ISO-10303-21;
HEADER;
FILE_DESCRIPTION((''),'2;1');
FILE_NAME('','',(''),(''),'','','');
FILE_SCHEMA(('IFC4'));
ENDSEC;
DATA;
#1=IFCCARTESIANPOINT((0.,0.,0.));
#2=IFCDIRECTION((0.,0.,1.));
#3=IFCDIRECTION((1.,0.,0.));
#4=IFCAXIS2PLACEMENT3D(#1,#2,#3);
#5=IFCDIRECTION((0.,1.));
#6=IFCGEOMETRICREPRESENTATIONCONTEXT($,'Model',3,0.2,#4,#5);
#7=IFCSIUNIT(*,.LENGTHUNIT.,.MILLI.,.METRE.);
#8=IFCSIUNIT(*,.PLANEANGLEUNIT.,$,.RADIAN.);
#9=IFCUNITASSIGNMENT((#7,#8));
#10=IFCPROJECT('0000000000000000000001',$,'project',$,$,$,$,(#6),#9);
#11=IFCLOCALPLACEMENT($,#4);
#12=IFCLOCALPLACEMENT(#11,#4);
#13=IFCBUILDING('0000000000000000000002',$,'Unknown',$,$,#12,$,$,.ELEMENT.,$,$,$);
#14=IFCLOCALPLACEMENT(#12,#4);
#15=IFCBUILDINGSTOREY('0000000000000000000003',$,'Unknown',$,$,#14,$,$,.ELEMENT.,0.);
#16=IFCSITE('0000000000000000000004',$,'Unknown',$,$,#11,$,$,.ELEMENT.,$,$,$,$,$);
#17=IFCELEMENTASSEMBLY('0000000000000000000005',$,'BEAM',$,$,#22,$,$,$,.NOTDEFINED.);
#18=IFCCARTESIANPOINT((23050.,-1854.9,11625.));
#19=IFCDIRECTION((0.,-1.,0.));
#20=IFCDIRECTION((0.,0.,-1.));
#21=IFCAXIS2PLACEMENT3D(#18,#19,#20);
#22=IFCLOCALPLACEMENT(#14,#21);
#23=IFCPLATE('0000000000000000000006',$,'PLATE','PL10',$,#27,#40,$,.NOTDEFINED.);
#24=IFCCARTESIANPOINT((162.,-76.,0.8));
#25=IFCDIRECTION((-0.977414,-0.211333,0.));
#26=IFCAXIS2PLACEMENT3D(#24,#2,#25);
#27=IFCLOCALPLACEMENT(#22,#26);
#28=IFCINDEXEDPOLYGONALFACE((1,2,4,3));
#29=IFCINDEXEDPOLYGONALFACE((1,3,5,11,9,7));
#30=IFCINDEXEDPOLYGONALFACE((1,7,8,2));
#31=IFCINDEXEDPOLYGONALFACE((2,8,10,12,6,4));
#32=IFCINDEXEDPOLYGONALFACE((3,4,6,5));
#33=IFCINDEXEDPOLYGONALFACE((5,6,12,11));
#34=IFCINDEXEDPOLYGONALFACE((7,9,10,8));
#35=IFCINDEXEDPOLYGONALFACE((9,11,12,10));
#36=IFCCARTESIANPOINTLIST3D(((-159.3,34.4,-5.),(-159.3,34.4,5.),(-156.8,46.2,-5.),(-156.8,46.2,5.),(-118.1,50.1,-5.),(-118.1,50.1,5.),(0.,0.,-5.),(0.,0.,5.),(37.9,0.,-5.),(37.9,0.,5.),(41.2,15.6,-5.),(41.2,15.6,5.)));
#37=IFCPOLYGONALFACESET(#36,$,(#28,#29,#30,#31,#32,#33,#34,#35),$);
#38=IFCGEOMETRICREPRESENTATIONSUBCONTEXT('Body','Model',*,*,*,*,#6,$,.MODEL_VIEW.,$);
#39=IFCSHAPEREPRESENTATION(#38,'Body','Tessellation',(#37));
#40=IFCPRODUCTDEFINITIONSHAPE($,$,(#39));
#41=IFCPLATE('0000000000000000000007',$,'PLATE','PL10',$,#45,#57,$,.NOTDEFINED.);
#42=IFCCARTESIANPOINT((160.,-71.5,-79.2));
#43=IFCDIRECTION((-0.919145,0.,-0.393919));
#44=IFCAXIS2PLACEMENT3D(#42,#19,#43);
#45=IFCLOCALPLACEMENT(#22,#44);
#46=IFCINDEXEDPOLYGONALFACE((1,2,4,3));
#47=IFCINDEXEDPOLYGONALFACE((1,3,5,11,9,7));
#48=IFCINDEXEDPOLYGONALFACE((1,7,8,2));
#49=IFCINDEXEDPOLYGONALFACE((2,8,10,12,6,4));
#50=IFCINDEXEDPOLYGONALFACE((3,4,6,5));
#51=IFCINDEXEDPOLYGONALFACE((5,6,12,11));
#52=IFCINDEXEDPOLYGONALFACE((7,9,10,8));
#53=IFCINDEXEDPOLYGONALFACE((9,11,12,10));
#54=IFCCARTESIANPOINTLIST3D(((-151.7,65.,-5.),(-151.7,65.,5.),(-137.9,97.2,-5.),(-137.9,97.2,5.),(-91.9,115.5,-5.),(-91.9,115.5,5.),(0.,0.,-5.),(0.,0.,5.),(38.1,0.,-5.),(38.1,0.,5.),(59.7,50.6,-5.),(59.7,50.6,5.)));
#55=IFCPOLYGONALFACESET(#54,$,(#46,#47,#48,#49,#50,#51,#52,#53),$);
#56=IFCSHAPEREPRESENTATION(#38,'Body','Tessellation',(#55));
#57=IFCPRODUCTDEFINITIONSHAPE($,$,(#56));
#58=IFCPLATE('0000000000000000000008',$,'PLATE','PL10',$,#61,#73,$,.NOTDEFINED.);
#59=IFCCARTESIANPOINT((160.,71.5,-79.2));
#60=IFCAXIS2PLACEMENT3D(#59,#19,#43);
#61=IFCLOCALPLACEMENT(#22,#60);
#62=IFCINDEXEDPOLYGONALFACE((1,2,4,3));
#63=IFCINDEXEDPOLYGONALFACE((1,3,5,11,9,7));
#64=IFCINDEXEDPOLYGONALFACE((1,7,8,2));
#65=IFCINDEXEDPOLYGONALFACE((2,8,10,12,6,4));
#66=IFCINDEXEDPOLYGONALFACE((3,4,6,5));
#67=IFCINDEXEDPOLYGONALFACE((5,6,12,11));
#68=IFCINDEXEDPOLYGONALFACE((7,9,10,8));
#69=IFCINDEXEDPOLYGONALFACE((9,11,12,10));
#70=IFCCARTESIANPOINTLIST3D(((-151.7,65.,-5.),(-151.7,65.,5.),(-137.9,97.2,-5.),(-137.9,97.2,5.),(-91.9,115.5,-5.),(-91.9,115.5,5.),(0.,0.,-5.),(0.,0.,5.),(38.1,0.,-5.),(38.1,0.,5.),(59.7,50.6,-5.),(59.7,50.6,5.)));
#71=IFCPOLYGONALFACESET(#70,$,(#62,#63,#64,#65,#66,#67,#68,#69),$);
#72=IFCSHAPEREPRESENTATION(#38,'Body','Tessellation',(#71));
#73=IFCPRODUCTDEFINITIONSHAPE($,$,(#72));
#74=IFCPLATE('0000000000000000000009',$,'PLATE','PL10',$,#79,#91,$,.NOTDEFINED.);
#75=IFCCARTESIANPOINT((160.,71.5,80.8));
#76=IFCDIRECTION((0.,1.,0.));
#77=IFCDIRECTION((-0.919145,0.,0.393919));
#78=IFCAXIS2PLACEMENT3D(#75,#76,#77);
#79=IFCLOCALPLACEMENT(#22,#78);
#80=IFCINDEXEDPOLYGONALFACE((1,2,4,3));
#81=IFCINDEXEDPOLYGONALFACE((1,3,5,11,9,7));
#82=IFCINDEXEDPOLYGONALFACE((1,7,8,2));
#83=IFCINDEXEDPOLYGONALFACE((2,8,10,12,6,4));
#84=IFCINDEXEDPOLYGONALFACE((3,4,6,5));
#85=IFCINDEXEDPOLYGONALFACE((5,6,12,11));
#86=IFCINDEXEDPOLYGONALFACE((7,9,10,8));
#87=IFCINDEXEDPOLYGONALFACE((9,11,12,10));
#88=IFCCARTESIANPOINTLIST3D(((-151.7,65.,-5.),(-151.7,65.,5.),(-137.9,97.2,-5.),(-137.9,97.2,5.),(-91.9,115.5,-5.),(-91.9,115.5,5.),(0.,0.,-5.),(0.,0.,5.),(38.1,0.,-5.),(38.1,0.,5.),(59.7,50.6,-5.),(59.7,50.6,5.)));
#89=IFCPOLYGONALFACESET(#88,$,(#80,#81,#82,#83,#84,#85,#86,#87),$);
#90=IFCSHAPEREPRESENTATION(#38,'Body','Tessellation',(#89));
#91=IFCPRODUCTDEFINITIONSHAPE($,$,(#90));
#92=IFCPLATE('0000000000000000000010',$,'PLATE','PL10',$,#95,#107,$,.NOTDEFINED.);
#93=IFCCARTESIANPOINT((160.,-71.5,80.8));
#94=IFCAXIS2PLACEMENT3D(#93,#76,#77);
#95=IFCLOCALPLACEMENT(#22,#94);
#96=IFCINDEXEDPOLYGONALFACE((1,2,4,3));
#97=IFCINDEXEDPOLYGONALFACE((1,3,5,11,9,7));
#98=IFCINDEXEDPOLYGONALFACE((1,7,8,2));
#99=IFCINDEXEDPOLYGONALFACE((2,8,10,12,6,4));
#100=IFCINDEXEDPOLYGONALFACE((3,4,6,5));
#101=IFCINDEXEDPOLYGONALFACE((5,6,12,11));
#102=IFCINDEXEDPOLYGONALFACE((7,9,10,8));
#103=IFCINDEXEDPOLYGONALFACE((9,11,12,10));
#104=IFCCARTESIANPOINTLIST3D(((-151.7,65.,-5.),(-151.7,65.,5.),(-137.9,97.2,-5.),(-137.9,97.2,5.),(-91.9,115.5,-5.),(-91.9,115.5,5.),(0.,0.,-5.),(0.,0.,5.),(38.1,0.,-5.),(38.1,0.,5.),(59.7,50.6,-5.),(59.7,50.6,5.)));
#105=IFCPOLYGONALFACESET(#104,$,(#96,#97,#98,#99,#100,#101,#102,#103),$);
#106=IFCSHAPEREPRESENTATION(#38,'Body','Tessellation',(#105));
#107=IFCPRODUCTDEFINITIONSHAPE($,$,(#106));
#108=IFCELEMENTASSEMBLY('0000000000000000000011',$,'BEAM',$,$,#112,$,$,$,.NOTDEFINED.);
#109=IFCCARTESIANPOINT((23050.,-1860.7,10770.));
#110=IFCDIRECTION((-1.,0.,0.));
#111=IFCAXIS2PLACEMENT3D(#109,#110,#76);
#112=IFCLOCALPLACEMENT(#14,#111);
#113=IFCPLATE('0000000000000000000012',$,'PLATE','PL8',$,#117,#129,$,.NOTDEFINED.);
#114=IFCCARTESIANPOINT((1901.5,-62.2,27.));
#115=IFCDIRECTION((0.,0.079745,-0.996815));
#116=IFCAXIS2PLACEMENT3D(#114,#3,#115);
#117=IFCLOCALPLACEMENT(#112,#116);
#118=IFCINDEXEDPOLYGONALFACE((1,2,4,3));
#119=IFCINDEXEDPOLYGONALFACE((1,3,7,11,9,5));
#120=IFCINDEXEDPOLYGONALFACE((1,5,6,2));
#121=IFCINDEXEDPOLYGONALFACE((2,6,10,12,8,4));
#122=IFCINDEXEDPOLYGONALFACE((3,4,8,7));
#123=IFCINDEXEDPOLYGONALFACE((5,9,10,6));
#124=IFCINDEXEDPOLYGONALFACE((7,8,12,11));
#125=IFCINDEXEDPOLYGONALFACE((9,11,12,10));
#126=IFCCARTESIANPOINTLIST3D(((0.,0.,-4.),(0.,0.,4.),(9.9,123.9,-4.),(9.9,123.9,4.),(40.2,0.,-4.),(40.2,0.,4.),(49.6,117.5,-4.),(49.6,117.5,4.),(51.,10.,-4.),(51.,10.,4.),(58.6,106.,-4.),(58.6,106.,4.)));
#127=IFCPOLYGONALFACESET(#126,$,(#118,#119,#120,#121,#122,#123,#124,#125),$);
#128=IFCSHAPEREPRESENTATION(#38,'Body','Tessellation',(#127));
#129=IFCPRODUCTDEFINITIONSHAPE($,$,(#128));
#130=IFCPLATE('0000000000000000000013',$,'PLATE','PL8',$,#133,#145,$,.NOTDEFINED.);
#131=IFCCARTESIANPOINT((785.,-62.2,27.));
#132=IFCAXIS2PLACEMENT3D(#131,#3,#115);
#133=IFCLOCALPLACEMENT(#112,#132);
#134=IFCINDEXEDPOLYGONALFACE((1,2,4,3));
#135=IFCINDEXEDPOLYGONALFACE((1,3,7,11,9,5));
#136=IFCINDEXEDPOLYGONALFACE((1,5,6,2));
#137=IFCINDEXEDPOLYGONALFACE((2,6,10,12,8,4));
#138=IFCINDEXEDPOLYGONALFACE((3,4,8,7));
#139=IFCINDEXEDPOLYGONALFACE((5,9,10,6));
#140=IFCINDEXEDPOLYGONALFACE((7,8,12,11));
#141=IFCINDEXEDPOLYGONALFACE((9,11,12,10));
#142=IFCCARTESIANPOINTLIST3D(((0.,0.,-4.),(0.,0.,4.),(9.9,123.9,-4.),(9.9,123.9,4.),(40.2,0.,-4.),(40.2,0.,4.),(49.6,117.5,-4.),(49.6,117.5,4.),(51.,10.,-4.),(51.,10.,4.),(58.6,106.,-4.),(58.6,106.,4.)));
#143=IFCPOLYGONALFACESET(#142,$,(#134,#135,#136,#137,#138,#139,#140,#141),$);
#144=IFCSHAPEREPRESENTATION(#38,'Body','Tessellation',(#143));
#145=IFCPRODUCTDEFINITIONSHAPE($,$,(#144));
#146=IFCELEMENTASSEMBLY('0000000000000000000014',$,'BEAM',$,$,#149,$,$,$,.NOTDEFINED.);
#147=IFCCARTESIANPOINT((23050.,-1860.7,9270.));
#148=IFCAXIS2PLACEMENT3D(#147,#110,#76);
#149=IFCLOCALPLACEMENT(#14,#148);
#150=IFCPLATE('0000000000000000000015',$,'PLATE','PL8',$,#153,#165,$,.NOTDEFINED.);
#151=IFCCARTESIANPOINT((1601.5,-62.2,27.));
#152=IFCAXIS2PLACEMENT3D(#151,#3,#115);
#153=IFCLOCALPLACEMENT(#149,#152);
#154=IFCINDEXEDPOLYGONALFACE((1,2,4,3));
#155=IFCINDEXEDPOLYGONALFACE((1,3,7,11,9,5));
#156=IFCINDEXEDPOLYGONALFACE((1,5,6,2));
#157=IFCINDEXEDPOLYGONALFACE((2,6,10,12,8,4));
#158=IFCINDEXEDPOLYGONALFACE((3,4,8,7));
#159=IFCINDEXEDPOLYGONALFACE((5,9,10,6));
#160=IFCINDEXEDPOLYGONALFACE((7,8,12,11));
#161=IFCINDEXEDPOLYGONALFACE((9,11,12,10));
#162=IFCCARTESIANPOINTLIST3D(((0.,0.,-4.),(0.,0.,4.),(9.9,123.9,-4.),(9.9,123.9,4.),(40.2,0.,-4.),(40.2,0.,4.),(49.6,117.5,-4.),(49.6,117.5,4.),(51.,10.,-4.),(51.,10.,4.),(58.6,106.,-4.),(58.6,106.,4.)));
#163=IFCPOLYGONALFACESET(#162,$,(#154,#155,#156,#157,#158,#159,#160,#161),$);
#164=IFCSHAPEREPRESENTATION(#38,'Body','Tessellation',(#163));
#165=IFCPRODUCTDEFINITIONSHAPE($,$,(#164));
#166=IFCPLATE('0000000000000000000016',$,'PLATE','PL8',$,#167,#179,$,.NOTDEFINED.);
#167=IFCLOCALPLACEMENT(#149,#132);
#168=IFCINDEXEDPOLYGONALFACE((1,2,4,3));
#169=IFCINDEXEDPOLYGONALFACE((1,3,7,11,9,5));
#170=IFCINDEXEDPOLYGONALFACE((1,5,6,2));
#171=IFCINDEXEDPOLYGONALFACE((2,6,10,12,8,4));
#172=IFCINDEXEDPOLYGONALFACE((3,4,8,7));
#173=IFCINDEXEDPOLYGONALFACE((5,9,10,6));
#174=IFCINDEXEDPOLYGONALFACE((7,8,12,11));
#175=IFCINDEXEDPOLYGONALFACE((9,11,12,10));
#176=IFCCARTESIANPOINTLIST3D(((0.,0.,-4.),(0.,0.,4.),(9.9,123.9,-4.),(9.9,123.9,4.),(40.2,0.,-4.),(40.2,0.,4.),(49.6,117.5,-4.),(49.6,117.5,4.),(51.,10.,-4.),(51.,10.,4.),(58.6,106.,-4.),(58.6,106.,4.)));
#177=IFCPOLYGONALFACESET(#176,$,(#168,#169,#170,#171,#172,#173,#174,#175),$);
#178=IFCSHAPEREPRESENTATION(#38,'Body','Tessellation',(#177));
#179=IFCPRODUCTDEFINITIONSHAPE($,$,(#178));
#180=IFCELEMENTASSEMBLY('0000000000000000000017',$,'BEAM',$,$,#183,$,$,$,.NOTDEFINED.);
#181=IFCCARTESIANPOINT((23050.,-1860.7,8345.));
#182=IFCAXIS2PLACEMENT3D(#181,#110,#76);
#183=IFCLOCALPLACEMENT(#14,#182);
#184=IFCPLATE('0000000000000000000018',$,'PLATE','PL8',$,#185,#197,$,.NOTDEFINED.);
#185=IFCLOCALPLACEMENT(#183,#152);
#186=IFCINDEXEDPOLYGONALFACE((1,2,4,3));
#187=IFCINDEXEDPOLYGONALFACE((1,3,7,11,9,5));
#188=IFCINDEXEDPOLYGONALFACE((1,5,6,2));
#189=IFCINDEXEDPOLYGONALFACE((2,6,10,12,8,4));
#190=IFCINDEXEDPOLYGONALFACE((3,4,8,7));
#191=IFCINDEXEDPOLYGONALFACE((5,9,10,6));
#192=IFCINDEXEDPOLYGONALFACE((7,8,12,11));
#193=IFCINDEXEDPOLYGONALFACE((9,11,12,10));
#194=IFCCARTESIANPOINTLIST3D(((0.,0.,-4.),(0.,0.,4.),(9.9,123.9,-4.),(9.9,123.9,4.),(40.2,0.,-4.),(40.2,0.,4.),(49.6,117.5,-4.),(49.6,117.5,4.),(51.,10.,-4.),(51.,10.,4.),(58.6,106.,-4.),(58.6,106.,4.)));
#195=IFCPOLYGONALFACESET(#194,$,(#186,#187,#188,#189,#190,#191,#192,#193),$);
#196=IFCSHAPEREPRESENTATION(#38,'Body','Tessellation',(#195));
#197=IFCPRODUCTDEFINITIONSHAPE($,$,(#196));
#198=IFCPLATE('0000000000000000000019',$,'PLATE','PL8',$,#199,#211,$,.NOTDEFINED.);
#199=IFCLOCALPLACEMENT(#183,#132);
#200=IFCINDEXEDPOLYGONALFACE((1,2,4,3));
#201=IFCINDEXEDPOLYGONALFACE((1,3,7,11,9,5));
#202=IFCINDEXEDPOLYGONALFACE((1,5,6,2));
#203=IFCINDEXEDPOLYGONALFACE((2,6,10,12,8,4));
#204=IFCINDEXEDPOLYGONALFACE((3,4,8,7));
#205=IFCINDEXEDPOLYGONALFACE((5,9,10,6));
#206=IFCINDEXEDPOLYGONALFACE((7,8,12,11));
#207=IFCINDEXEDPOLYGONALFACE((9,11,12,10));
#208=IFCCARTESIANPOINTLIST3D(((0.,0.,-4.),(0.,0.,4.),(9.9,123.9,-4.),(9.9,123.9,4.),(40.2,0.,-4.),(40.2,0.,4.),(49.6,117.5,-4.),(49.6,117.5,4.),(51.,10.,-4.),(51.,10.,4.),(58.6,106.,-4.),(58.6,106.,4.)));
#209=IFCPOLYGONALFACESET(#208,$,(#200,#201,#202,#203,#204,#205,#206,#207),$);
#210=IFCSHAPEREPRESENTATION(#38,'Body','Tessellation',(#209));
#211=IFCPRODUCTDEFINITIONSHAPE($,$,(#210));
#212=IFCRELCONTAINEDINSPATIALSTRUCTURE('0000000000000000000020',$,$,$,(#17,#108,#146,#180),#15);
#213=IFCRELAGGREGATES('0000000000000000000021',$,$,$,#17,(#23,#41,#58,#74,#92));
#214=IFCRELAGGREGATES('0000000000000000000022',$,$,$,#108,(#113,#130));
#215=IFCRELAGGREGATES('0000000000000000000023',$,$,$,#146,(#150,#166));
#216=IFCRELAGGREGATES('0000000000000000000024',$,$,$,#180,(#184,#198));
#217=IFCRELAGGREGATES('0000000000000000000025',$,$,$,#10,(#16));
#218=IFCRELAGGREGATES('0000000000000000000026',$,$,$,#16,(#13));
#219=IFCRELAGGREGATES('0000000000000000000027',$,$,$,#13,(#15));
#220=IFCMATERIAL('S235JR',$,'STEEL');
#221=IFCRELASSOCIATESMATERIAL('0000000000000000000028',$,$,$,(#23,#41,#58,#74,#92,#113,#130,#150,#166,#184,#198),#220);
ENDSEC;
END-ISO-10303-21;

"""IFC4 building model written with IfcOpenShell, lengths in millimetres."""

from ifc_helpers import new_model, si_unit, direction, frame, origin_with_axes, place, context, subcontext, project, spatial, line, indexed_curve, outline, extrude, material, element, aggregate, save


model = new_model("IFC4")

# Units and contexts
model_context = context("Model", 3, precision=0.2, world=origin_with_axes(), true_north=direction((0.0, 1.0)))
body_context = subcontext(model_context, "Body", "Model", "MODEL_VIEW")
ifc_project = project(units=[si_unit("LENGTHUNIT", "METRE", prefix="MILLI"), si_unit("PLANEANGLEUNIT", "RADIAN")], contexts=[model_context])

# Site, building, storey
site_placement = place(None, origin_with_axes())
site = spatial("IfcSite", under=ifc_project, at=site_placement, Name="Unknown", CompositionType="ELEMENT")
building_placement = place(site_placement, origin_with_axes())
building = spatial("IfcBuilding", under=site, at=building_placement, Name="Unknown", CompositionType="ELEMENT")
storey_placement = place(building_placement, origin_with_axes())
storey = spatial("IfcBuildingStorey", under=building, at=storey_placement, Name="Unknown", CompositionType="ELEMENT", Elevation=0.0)

# Shared definitions
ifc_material = material(Name="S235JR", Category="STEEL")

# Element assembly, plates
assembly_1_placement = place(storey_placement, frame((23050.0, -1854.9, 11625.0), z_axis=(0.0, -1.0, 0.0), x_axis=(0.0, 0.0, -1.0)))
assembly_1 = element("IfcElementAssembly", 1, at=assembly_1_placement, inside=storey, Name="BEAM", PredefinedType="NOTDEFINED")
plate_1_placement = place(assembly_1_placement, frame((162.0, -76.0, 0.8), z_axis=(0.0, 0.0, 1.0), x_axis=(-0.977414, -0.211333, 0.0)))
plate_1 = element("IfcPlate", 2, at=plate_1_placement, material=ifc_material, Name="PLATE", Description="PL10", PredefinedType="NOTDEFINED", context=body_context, shape_type="SolidModel", body=[
    extrude(outline(indexed_curve([(0.0, 0.0), (37.9, 0.0), (41.2, 15.6), (-118.1, 50.1), (-156.8, 46.2), (-159.3, 34.4)], segments=[line(1, 2, 3, 4, 5, 6, 1)])), frame((0.0, 0.0, 5.0), z_axis=(0.0, 0.0, 1.0), x_axis=(1.0, 0.0, 0.0)), (0.0, 0.0, -1.0), 10.0),
])
plate_2_placement = place(assembly_1_placement, frame((160.0, -71.5, -79.2), z_axis=(0.0, -1.0, 0.0), x_axis=(-0.919145, 0.0, -0.393919)))
plate_2 = element("IfcPlate", 3, at=plate_2_placement, material=ifc_material, Name="PLATE", Description="PL10", PredefinedType="NOTDEFINED", context=body_context, shape_type="SolidModel", body=[
    extrude(outline(indexed_curve([(0.0, 0.0), (38.1, 0.0), (59.7, 50.6), (-91.9, 115.5), (-137.9, 97.2), (-151.7, 65.0)], segments=[line(1, 2, 3, 4, 5, 6, 1)])), frame((0.0, 0.0, 5.0), z_axis=(0.0, 0.0, 1.0), x_axis=(1.0, 0.0, 0.0)), (0.0, 0.0, -1.0), 10.0),
])
plate_3_placement = place(assembly_1_placement, frame((160.0, 71.5, -79.2), z_axis=(0.0, -1.0, 0.0), x_axis=(-0.919145, 0.0, -0.393919)))
plate_3 = element("IfcPlate", 4, at=plate_3_placement, material=ifc_material, Name="PLATE", Description="PL10", PredefinedType="NOTDEFINED", context=body_context, shape_type="SolidModel", body=[
    extrude(outline(indexed_curve([(0.0, 0.0), (38.1, 0.0), (59.7, 50.6), (-91.9, 115.5), (-137.9, 97.2), (-151.7, 65.0)], segments=[line(1, 2, 3, 4, 5, 6, 1)])), frame((0.0, 0.0, 5.0), z_axis=(0.0, 0.0, 1.0), x_axis=(1.0, 0.0, 0.0)), (0.0, 0.0, -1.0), 10.0),
])
plate_4_placement = place(assembly_1_placement, frame((160.0, 71.5, 80.8), z_axis=(0.0, 1.0, 0.0), x_axis=(-0.919145, 0.0, 0.393919)))
plate_4 = element("IfcPlate", 5, at=plate_4_placement, material=ifc_material, Name="PLATE", Description="PL10", PredefinedType="NOTDEFINED", context=body_context, shape_type="SolidModel", body=[
    extrude(outline(indexed_curve([(0.0, 0.0), (38.1, 0.0), (59.7, 50.6), (-91.9, 115.5), (-137.9, 97.2), (-151.7, 65.0)], segments=[line(1, 2, 3, 4, 5, 6, 1)])), frame((0.0, 0.0, 5.0), z_axis=(0.0, 0.0, 1.0), x_axis=(1.0, 0.0, 0.0)), (0.0, 0.0, -1.0), 10.0),
])
plate_5_placement = place(assembly_1_placement, frame((160.0, -71.5, 80.8), z_axis=(0.0, 1.0, 0.0), x_axis=(-0.919145, 0.0, 0.393919)))
plate_5 = element("IfcPlate", 6, at=plate_5_placement, material=ifc_material, Name="PLATE", Description="PL10", PredefinedType="NOTDEFINED", context=body_context, shape_type="SolidModel", body=[
    extrude(outline(indexed_curve([(0.0, 0.0), (38.1, 0.0), (59.7, 50.6), (-91.9, 115.5), (-137.9, 97.2), (-151.7, 65.0)], segments=[line(1, 2, 3, 4, 5, 6, 1)])), frame((0.0, 0.0, 5.0), z_axis=(0.0, 0.0, 1.0), x_axis=(1.0, 0.0, 0.0)), (0.0, 0.0, -1.0), 10.0),
])
aggregate(assembly_1, [plate_1, plate_2, plate_3, plate_4, plate_5])

# Element assemblies, plates
assembly_2_placement = place(storey_placement, frame((23050.0, -1860.7, 10770.0), z_axis=(-1.0, 0.0, 0.0), x_axis=(0.0, 1.0, 0.0)))
assembly_2 = element("IfcElementAssembly", 7, at=assembly_2_placement, inside=storey, Name="BEAM", PredefinedType="NOTDEFINED")
plate_6_placement = place(assembly_2_placement, frame((1901.5, -62.2, 27.0), z_axis=(1.0, 0.0, 0.0), x_axis=(0.0, 0.079745, -0.996815)))
plate_6 = element("IfcPlate", 8, at=plate_6_placement, material=ifc_material, Name="PLATE", Description="PL8", PredefinedType="NOTDEFINED", context=body_context, shape_type="SolidModel", body=[
    extrude(outline(indexed_curve([(0.0, 0.0), (40.2, 0.0), (51.0, 10.0), (58.6, 106.0), (49.6, 117.5), (9.9, 123.9)], segments=[line(1, 2, 3, 4, 5, 6, 1)])), frame((0.0, 0.0, 4.0), z_axis=(0.0, 0.0, 1.0), x_axis=(1.0, 0.0, 0.0)), (0.0, 0.0, -1.0), 8.0),
])
plate_7_placement = place(assembly_2_placement, frame((785.0, -62.2, 27.0), z_axis=(1.0, 0.0, 0.0), x_axis=(0.0, 0.079745, -0.996815)))
plate_7 = element("IfcPlate", 9, at=plate_7_placement, material=ifc_material, Name="PLATE", Description="PL8", PredefinedType="NOTDEFINED", context=body_context, shape_type="SolidModel", body=[
    extrude(outline(indexed_curve([(0.0, 0.0), (40.2, 0.0), (51.0, 10.0), (58.6, 106.0), (49.6, 117.5), (9.9, 123.9)], segments=[line(1, 2, 3, 4, 5, 6, 1)])), frame((0.0, 0.0, 4.0), z_axis=(0.0, 0.0, 1.0), x_axis=(1.0, 0.0, 0.0)), (0.0, 0.0, -1.0), 8.0),
])
aggregate(assembly_2, [plate_6, plate_7])
assembly_3_placement = place(storey_placement, frame((23050.0, -1860.7, 9270.0), z_axis=(-1.0, 0.0, 0.0), x_axis=(0.0, 1.0, 0.0)))
assembly_3 = element("IfcElementAssembly", 10, at=assembly_3_placement, inside=storey, Name="BEAM", PredefinedType="NOTDEFINED")
plate_8_placement = place(assembly_3_placement, frame((1601.5, -62.2, 27.0), z_axis=(1.0, 0.0, 0.0), x_axis=(0.0, 0.079745, -0.996815)))
plate_8 = element("IfcPlate", 11, at=plate_8_placement, material=ifc_material, Name="PLATE", Description="PL8", PredefinedType="NOTDEFINED", context=body_context, shape_type="SolidModel", body=[
    extrude(outline(indexed_curve([(0.0, 0.0), (40.2, 0.0), (51.0, 10.0), (58.6, 106.0), (49.6, 117.5), (9.9, 123.9)], segments=[line(1, 2, 3, 4, 5, 6, 1)])), frame((0.0, 0.0, 4.0), z_axis=(0.0, 0.0, 1.0), x_axis=(1.0, 0.0, 0.0)), (0.0, 0.0, -1.0), 8.0),
])
plate_9_placement = place(assembly_3_placement, frame((785.0, -62.2, 27.0), z_axis=(1.0, 0.0, 0.0), x_axis=(0.0, 0.079745, -0.996815)))
plate_9 = element("IfcPlate", 12, at=plate_9_placement, material=ifc_material, Name="PLATE", Description="PL8", PredefinedType="NOTDEFINED", context=body_context, shape_type="SolidModel", body=[
    extrude(outline(indexed_curve([(0.0, 0.0), (40.2, 0.0), (51.0, 10.0), (58.6, 106.0), (49.6, 117.5), (9.9, 123.9)], segments=[line(1, 2, 3, 4, 5, 6, 1)])), frame((0.0, 0.0, 4.0), z_axis=(0.0, 0.0, 1.0), x_axis=(1.0, 0.0, 0.0)), (0.0, 0.0, -1.0), 8.0),
])
aggregate(assembly_3, [plate_8, plate_9])
assembly_4_placement = place(storey_placement, frame((23050.0, -1860.7, 8345.0), z_axis=(-1.0, 0.0, 0.0), x_axis=(0.0, 1.0, 0.0)))
assembly_4 = element("IfcElementAssembly", 13, at=assembly_4_placement, inside=storey, Name="BEAM", PredefinedType="NOTDEFINED")
plate_10_placement = place(assembly_4_placement, frame((1601.5, -62.2, 27.0), z_axis=(1.0, 0.0, 0.0), x_axis=(0.0, 0.079745, -0.996815)))
plate_10 = element("IfcPlate", 14, at=plate_10_placement, material=ifc_material, Name="PLATE", Description="PL8", PredefinedType="NOTDEFINED", context=body_context, shape_type="SolidModel", body=[
    extrude(outline(indexed_curve([(0.0, 0.0), (40.2, 0.0), (51.0, 10.0), (58.6, 106.0), (49.6, 117.5), (9.9, 123.9)], segments=[line(1, 2, 3, 4, 5, 6, 1)])), frame((0.0, 0.0, 4.0), z_axis=(0.0, 0.0, 1.0), x_axis=(1.0, 0.0, 0.0)), (0.0, 0.0, -1.0), 8.0),
])
plate_11_placement = place(assembly_4_placement, frame((785.0, -62.2, 27.0), z_axis=(1.0, 0.0, 0.0), x_axis=(0.0, 0.079745, -0.996815)))
plate_11 = element("IfcPlate", 15, at=plate_11_placement, material=ifc_material, Name="PLATE", Description="PL8", PredefinedType="NOTDEFINED", context=body_context, shape_type="SolidModel", body=[
    extrude(outline(indexed_curve([(0.0, 0.0), (40.2, 0.0), (51.0, 10.0), (58.6, 106.0), (49.6, 117.5), (9.9, 123.9)], segments=[line(1, 2, 3, 4, 5, 6, 1)])), frame((0.0, 0.0, 4.0), z_axis=(0.0, 0.0, 1.0), x_axis=(1.0, 0.0, 0.0)), (0.0, 0.0, -1.0), 8.0),
])
aggregate(assembly_4, [plate_10, plate_11])

save(model, "model.ifc")
